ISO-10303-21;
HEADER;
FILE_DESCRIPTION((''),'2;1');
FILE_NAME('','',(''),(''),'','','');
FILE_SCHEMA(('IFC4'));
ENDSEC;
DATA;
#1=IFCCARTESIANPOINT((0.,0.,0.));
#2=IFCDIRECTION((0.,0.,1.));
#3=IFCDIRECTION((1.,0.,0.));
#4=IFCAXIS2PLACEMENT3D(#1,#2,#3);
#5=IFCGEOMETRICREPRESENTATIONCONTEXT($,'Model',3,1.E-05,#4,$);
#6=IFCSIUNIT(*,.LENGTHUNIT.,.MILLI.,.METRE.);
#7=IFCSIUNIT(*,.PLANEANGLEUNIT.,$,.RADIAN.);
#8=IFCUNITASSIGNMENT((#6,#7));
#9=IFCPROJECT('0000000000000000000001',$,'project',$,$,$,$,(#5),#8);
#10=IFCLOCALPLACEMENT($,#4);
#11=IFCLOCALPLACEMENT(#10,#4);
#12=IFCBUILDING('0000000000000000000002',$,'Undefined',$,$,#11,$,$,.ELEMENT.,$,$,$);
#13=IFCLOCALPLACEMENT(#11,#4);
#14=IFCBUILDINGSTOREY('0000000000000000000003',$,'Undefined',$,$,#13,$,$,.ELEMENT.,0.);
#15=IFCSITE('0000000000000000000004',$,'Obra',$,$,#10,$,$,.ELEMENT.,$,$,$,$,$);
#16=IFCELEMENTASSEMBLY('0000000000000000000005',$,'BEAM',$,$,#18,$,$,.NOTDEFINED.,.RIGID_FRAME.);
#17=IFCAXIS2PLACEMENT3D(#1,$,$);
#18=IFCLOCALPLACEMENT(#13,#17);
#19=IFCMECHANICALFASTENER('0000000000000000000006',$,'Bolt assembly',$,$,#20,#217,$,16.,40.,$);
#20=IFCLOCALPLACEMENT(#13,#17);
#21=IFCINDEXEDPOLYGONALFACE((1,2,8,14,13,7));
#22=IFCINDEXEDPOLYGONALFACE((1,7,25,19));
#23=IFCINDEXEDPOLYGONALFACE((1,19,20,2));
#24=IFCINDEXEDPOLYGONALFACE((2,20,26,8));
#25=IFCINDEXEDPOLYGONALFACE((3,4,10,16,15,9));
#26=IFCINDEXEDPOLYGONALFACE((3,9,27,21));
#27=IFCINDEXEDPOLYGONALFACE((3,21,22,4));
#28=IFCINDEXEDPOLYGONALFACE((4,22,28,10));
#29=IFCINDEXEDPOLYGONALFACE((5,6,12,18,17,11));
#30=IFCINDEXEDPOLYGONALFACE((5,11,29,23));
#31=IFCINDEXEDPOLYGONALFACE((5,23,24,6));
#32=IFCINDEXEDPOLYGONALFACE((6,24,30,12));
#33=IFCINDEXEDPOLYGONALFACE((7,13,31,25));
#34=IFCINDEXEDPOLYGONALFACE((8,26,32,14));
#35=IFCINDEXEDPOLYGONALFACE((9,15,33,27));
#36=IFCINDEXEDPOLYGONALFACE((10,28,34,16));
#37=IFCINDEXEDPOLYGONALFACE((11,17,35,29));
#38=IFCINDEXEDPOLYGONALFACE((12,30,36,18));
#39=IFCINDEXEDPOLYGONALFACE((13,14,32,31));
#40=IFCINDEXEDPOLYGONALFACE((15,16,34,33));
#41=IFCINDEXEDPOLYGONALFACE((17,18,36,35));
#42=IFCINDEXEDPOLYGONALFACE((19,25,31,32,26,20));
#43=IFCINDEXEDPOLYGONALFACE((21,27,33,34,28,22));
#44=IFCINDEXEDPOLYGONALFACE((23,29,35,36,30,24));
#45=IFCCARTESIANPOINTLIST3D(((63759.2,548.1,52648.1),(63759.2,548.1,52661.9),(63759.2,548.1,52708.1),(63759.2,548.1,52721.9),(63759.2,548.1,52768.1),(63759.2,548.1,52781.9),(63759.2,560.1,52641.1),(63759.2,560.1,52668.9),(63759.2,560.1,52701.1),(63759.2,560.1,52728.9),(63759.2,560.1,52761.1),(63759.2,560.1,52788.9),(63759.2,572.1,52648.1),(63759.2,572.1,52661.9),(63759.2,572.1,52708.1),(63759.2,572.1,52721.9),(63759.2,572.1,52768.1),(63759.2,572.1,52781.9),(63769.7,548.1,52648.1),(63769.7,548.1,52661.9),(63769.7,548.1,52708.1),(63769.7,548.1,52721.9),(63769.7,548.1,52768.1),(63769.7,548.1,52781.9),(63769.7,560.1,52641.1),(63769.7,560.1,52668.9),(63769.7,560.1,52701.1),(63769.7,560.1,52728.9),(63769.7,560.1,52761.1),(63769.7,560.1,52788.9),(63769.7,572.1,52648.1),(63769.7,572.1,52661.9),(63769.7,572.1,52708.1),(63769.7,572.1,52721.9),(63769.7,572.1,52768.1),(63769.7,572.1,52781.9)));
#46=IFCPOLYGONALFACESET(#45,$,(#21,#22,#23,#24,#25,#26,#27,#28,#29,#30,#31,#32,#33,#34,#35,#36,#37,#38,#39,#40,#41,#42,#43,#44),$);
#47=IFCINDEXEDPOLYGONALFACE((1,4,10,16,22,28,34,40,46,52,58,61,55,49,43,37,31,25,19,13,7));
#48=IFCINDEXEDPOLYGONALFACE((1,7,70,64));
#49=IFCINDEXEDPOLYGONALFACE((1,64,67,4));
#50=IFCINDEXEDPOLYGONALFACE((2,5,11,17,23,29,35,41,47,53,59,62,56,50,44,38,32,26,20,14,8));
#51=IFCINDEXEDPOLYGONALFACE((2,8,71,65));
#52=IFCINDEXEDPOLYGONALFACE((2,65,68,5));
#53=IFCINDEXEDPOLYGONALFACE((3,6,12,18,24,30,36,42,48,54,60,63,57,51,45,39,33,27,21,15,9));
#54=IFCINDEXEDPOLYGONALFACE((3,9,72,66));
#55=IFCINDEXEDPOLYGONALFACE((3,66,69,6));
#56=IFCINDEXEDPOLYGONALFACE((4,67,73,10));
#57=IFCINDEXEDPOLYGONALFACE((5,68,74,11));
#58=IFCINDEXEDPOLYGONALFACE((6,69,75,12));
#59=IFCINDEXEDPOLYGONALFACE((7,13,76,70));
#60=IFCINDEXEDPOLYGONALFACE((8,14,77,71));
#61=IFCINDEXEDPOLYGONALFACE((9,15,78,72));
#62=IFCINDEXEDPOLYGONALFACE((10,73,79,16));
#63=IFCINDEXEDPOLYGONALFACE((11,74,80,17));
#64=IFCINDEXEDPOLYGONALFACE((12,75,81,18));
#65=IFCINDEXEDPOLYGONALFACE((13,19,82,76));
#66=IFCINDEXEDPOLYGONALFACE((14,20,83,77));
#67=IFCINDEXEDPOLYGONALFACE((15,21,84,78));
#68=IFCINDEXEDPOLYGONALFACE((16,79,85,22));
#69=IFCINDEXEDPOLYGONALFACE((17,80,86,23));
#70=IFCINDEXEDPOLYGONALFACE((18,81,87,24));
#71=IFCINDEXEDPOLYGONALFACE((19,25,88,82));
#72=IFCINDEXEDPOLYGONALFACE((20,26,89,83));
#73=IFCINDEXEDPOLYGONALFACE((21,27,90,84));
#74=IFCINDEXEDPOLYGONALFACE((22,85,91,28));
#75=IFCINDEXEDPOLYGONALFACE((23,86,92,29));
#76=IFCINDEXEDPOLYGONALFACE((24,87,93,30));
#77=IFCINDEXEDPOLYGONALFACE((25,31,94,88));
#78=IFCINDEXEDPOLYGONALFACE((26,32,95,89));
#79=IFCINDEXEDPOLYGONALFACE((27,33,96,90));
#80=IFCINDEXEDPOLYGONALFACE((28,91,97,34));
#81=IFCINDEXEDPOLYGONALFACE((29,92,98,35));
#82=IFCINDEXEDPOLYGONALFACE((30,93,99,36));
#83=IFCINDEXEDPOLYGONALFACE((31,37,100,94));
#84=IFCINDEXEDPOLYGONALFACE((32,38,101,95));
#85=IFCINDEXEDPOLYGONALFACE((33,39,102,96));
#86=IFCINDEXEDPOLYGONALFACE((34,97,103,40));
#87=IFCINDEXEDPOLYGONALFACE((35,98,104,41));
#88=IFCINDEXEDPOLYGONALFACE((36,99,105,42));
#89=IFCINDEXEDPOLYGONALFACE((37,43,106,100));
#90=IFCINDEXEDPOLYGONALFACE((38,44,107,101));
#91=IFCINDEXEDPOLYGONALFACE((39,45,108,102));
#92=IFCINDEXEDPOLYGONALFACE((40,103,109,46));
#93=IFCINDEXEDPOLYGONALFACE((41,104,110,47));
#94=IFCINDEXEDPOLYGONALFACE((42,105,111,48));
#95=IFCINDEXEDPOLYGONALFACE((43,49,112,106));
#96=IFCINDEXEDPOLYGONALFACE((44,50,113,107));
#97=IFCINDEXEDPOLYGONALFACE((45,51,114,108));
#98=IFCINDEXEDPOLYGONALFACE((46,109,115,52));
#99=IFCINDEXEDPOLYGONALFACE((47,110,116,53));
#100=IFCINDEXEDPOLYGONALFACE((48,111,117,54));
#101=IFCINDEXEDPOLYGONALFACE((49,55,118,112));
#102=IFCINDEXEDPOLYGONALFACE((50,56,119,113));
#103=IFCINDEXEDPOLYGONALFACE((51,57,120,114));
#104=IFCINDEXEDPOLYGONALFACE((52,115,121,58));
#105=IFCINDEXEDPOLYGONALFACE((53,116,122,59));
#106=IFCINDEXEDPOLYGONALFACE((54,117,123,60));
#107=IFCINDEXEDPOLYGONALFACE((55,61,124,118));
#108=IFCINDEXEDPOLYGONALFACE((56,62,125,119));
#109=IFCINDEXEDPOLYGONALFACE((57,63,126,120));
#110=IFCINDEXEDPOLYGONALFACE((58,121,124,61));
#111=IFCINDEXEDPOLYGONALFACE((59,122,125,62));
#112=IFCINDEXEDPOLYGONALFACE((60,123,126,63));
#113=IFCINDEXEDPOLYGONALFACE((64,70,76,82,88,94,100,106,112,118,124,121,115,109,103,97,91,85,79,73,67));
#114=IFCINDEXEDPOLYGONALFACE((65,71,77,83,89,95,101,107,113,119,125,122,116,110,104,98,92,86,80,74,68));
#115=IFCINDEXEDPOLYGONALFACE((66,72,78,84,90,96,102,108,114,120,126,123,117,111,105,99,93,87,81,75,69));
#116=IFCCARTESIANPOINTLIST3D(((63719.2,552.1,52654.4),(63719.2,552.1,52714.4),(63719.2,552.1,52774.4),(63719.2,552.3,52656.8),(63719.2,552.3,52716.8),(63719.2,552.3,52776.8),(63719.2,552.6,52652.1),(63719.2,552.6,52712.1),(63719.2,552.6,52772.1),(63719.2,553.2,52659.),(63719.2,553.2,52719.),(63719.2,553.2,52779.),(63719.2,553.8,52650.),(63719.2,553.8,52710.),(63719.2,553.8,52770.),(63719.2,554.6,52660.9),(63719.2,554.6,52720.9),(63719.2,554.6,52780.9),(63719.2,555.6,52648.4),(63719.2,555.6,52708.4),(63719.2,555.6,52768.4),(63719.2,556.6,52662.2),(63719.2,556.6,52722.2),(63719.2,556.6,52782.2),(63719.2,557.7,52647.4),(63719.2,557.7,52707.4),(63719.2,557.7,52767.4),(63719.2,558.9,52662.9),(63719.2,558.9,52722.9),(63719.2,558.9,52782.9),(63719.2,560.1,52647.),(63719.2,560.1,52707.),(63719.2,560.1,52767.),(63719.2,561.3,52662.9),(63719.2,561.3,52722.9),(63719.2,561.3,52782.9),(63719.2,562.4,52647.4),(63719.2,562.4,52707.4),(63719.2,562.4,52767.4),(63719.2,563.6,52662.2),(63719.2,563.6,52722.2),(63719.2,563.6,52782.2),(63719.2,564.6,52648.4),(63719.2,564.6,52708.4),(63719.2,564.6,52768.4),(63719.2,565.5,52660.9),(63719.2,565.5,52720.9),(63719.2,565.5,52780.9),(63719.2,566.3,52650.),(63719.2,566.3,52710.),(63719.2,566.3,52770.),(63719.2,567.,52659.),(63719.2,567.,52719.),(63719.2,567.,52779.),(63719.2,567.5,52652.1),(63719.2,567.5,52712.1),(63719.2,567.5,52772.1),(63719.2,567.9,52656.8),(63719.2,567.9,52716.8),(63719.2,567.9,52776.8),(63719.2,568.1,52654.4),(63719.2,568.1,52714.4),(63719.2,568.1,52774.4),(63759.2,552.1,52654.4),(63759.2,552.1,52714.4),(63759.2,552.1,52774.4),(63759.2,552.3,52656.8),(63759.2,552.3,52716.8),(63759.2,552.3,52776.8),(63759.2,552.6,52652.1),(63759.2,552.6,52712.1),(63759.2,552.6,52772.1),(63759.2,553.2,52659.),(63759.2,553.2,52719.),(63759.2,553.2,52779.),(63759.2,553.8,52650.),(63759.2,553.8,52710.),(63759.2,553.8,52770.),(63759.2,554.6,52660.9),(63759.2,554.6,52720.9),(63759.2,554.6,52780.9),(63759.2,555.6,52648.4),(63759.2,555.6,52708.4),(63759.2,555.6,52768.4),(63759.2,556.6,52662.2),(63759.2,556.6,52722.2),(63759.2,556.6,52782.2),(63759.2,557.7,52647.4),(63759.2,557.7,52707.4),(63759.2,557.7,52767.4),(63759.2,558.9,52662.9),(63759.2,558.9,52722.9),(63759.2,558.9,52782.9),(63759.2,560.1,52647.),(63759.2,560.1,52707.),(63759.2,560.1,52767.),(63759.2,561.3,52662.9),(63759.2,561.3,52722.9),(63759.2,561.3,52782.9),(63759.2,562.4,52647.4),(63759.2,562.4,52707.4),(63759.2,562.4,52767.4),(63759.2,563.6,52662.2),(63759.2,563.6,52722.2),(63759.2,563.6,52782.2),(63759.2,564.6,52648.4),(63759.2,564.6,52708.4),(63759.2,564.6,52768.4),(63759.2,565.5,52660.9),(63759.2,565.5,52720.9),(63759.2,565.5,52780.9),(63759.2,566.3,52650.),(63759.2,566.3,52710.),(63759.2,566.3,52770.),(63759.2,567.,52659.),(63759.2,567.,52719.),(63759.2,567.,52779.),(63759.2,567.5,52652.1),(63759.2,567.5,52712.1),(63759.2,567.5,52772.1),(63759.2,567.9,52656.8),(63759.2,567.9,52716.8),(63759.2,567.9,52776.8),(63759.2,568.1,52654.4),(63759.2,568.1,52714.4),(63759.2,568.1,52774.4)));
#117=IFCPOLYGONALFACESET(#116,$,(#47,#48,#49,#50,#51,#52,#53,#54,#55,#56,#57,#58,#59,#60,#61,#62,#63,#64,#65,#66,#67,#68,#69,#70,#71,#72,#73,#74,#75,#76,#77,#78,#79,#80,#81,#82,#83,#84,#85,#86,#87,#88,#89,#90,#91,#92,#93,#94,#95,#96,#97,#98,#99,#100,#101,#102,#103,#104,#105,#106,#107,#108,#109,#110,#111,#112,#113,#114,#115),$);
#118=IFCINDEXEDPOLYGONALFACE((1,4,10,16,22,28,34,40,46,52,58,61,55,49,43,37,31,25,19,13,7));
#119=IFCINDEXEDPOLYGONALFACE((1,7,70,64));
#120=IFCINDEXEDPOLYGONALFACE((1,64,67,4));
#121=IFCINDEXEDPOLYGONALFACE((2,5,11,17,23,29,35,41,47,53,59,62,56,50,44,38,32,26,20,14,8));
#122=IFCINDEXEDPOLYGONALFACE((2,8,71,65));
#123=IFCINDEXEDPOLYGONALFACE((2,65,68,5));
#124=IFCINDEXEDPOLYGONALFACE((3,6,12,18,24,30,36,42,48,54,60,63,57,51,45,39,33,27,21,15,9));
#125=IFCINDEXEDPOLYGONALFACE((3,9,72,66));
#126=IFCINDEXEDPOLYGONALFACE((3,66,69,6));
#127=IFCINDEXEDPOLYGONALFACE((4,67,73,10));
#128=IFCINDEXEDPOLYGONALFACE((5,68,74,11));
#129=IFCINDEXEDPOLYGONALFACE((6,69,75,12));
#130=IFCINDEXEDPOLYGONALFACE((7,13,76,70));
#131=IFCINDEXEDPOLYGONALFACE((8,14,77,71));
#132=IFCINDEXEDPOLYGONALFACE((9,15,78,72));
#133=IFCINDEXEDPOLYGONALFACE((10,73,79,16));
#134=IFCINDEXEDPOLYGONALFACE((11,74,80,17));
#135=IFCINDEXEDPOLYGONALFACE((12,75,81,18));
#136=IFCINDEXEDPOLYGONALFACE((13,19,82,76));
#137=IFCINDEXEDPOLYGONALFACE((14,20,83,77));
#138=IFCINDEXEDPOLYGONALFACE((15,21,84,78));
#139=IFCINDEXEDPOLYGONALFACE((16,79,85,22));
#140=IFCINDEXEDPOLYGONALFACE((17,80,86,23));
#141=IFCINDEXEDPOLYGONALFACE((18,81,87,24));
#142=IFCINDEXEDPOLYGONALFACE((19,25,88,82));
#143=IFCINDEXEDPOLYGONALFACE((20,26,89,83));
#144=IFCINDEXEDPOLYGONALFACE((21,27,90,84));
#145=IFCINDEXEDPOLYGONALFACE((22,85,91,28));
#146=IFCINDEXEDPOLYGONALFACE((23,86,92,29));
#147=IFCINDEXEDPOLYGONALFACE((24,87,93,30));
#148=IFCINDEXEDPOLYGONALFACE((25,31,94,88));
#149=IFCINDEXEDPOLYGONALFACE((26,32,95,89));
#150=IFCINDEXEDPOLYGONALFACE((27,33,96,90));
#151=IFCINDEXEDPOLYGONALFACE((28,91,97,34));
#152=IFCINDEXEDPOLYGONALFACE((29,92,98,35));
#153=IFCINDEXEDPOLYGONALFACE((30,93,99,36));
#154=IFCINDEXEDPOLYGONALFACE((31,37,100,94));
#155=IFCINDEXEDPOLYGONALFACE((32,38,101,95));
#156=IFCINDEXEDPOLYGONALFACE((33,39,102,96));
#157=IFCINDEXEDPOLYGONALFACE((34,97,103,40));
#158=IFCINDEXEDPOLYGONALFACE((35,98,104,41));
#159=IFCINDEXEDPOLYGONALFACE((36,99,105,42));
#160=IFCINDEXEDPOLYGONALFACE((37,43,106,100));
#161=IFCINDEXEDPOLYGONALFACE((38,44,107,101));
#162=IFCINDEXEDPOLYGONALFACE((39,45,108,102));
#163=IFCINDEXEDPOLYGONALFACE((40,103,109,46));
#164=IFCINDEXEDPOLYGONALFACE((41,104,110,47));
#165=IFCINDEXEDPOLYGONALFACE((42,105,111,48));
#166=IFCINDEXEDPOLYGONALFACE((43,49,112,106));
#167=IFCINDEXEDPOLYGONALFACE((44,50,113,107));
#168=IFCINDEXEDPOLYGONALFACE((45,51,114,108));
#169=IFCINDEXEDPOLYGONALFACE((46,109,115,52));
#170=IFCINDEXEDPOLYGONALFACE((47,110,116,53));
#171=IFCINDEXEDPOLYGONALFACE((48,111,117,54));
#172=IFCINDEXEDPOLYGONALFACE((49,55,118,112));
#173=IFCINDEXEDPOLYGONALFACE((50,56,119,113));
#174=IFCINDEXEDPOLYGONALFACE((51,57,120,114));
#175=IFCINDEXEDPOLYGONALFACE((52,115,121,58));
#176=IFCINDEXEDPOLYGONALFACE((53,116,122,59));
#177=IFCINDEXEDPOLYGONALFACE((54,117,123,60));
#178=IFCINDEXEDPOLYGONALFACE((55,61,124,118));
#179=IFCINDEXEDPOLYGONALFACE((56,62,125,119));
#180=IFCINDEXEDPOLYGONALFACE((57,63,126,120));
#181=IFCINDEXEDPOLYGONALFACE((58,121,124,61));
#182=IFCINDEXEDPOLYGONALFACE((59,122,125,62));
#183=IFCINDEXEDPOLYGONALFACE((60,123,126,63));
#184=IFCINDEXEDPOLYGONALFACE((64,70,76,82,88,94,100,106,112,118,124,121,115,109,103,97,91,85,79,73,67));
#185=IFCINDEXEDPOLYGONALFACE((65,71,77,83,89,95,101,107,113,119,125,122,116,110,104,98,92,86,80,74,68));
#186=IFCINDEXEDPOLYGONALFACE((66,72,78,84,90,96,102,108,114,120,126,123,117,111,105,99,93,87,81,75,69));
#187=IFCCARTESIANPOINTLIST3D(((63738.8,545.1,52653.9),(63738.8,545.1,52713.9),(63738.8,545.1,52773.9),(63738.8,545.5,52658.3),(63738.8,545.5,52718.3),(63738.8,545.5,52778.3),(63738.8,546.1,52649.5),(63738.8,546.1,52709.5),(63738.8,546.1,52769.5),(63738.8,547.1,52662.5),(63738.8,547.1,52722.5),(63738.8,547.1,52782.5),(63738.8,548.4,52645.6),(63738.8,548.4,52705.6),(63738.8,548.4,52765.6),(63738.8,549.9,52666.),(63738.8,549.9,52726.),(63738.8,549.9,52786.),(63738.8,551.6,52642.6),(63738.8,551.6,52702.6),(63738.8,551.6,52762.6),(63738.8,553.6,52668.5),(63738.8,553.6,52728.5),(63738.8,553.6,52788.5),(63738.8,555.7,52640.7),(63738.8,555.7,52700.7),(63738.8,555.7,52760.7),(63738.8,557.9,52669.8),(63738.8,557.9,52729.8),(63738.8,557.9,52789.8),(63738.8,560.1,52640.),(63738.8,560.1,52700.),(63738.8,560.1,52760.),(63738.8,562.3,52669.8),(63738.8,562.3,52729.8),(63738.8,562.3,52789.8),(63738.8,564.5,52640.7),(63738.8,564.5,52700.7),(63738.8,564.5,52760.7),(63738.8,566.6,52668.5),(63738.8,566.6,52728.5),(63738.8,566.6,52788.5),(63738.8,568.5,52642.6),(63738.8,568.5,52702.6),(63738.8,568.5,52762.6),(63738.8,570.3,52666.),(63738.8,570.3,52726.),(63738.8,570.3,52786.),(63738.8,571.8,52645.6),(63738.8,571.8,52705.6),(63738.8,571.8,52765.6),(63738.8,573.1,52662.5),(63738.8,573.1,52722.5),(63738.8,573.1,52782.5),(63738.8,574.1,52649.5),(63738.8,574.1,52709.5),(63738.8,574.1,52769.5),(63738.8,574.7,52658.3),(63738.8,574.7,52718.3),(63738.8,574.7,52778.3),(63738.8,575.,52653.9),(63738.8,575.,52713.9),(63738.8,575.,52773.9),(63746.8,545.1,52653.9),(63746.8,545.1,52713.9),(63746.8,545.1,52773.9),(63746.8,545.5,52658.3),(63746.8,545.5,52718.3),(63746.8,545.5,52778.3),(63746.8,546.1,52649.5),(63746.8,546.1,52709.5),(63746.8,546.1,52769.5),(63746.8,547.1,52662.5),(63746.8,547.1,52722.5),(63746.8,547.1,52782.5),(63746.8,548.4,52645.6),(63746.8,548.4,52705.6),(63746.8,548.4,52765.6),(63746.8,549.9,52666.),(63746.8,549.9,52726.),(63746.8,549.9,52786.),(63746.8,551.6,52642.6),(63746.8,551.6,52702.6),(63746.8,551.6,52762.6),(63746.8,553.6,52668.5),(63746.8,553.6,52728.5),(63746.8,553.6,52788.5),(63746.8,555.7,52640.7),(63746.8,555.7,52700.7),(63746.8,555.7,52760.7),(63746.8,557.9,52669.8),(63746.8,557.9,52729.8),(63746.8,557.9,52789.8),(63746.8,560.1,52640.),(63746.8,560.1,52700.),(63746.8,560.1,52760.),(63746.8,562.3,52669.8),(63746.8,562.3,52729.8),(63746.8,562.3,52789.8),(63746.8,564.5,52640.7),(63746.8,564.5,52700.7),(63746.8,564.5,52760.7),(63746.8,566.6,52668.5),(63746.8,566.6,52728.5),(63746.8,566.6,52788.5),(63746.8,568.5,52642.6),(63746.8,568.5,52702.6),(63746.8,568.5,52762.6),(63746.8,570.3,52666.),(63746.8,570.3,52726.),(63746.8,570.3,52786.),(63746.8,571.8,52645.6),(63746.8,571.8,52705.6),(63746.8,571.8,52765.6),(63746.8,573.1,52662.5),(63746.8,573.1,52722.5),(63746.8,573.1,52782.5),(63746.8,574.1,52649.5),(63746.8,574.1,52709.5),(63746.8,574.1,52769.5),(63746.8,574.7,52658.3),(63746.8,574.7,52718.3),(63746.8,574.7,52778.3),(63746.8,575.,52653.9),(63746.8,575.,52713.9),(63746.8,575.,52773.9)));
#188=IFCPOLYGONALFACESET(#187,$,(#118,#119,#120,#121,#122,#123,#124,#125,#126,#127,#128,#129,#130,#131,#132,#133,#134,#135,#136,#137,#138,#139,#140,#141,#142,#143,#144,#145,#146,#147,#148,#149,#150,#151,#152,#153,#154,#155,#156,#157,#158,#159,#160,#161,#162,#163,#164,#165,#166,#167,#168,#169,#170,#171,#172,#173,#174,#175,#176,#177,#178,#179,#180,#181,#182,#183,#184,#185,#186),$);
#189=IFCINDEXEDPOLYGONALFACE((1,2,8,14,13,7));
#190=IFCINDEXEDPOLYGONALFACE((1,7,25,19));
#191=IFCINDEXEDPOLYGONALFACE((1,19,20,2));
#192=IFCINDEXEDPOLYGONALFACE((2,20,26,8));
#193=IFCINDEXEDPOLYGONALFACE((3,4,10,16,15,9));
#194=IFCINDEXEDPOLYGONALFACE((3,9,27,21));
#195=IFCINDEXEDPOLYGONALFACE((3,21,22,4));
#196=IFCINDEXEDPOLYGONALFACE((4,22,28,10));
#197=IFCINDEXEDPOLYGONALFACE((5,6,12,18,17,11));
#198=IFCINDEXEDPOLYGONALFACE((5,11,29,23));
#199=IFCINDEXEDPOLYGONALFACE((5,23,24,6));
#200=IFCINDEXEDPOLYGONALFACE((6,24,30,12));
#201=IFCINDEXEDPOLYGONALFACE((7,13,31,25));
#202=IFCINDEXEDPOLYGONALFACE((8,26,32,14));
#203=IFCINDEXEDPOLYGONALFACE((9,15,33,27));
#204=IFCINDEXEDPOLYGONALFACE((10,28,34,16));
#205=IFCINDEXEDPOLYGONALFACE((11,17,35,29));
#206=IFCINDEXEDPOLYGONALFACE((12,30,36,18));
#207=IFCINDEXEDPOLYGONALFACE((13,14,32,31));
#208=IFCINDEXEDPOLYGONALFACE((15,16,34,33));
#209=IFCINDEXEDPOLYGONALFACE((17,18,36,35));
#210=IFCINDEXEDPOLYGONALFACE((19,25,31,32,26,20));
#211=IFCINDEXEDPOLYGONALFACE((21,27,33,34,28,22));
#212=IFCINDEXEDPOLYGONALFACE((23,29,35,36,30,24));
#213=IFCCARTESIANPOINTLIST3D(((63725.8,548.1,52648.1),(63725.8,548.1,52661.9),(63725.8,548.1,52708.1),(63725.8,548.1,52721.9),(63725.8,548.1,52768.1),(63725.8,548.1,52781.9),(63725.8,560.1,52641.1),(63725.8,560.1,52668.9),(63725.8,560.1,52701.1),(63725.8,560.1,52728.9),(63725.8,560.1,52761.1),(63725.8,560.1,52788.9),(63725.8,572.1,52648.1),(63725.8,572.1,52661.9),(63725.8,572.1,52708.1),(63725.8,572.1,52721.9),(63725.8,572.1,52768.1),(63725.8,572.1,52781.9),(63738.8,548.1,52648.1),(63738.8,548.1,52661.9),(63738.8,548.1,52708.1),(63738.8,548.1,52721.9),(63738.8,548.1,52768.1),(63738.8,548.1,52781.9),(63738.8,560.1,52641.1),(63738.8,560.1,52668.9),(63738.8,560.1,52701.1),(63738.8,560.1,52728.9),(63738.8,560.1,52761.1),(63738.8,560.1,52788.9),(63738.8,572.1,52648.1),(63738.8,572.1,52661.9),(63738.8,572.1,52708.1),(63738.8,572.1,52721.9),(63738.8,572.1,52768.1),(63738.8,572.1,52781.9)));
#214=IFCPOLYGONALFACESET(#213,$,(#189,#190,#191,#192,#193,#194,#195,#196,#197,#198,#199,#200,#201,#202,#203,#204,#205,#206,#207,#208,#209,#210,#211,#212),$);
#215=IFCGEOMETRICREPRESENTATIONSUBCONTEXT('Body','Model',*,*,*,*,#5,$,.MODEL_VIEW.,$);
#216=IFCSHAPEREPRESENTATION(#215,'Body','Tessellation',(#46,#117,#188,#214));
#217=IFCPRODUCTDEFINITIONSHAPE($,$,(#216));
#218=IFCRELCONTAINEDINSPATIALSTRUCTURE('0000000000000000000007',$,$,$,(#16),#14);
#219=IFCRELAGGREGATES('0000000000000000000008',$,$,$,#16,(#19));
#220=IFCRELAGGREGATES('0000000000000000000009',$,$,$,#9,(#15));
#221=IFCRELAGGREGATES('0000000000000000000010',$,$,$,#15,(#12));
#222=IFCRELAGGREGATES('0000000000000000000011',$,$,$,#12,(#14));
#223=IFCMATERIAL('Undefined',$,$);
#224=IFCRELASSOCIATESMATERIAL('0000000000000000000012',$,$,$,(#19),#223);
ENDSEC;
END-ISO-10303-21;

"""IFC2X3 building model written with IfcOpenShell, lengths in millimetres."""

from ifc_helpers import new_model, si_unit, frame, origin_with_axes, origin_2d_with_axis, place, context, subcontext, project, spatial, polyline, circle, outline, extrude, source, transform, mapped, material, element, aggregate, save


model = new_model("IFC2X3")

# Units and contexts
model_context = context("Model", 3, precision=1e-05, world=origin_with_axes())
body_context = subcontext(model_context, "Body", "Model", "MODEL_VIEW")
ifc_project = project(units=[si_unit("LENGTHUNIT", "METRE", prefix="MILLI"), si_unit("PLANEANGLEUNIT", "RADIAN")], contexts=[model_context])

# Site, building, storey
site_placement = place(None, origin_with_axes())
site = spatial("IfcSite", under=ifc_project, at=site_placement, Name="Obra", CompositionType="ELEMENT")
building_placement = place(site_placement, origin_with_axes())
building = spatial("IfcBuilding", under=site, at=building_placement, Name="Undefined", CompositionType="ELEMENT")
storey_placement = place(building_placement, origin_with_axes())
storey = spatial("IfcBuildingStorey", under=building, at=storey_placement, Name="Undefined", CompositionType="ELEMENT", Elevation=0.0)

# Element assembly
assembly_1_placement = place(storey_placement, origin_with_axes())
assembly_1 = element("IfcElementAssembly", 1, at=assembly_1_placement, inside=storey, Name="BEAM", AssemblyPlace="NOTDEFINED", PredefinedType="RIGID_FRAME")

# Shared definitions
ifc_material_1 = material(Name="Undefined")
shared_shape_1 = source(origin_with_axes(), body_context, "Body", "SweptSolid", [
    extrude(outline(polyline([(13.9, 0.0), (6.9, 12.0), (-6.9, 12.0), (-13.9, 0.0), (-6.9, -12.0), (6.9, -12.0), (13.9, 0.0)])), frame((0.0, -19.7, 0.0), z_axis=(0.0, 1.0, 0.0), x_axis=(1.0, 0.0, 0.0)), (0.0, 0.0, 1.0), 10.6),
    extrude(circle(Radius=8.0, at=origin_2d_with_axis()), frame((0.0, -9.1, 0.0), z_axis=(0.0, 1.0, 0.0), x_axis=(1.0, 0.0, 0.0)), (0.0, 0.0, 1.0), 40.0),
    extrude(circle(Radius=15.0, at=origin_2d_with_axis()), frame((0.0, 3.3, 0.0), z_axis=(0.0, 1.0, 0.0), x_axis=(1.0, 0.0, 0.0)), (0.0, 0.0, 1.0), 8.0),
    extrude(outline(polyline([(13.9, 0.0), (6.9, 12.0), (-6.9, 12.0), (-13.9, 0.0), (-6.9, -12.0), (6.9, -12.0), (13.9, 0.0)])), frame((0.0, 11.3, 0.0), z_axis=(0.0, 1.0, 0.0), x_axis=(1.0, 0.0, 0.0)), (0.0, 0.0, 1.0), 13.0),
])

# Mechanical fastener
mechanical_fastener_1_placement = place(assembly_1_placement, frame((63750.1, 510.1, 52835.0), z_axis=(-0.000002, 1.0, 0.0), x_axis=(0.0, 0.0, -1.0)))
mechanical_fastener_1 = element("IfcMechanicalFastener", 2, at=mechanical_fastener_1_placement, material=ifc_material_1, Name="Bolt assembly", NominalDiameter=16.0, NominalLength=40.0, context=body_context, shape_type="MappedRepresentation", body=[
    mapped(shared_shape_1, transform((60.0, 0.0, 50.0))),
    mapped(shared_shape_1, transform((120.0, 0.0, 50.0))),
    mapped(shared_shape_1, transform((180.0, 0.0, 50.0))),
])
aggregate(assembly_1, [mechanical_fastener_1])

save(model, "model.ifc")
